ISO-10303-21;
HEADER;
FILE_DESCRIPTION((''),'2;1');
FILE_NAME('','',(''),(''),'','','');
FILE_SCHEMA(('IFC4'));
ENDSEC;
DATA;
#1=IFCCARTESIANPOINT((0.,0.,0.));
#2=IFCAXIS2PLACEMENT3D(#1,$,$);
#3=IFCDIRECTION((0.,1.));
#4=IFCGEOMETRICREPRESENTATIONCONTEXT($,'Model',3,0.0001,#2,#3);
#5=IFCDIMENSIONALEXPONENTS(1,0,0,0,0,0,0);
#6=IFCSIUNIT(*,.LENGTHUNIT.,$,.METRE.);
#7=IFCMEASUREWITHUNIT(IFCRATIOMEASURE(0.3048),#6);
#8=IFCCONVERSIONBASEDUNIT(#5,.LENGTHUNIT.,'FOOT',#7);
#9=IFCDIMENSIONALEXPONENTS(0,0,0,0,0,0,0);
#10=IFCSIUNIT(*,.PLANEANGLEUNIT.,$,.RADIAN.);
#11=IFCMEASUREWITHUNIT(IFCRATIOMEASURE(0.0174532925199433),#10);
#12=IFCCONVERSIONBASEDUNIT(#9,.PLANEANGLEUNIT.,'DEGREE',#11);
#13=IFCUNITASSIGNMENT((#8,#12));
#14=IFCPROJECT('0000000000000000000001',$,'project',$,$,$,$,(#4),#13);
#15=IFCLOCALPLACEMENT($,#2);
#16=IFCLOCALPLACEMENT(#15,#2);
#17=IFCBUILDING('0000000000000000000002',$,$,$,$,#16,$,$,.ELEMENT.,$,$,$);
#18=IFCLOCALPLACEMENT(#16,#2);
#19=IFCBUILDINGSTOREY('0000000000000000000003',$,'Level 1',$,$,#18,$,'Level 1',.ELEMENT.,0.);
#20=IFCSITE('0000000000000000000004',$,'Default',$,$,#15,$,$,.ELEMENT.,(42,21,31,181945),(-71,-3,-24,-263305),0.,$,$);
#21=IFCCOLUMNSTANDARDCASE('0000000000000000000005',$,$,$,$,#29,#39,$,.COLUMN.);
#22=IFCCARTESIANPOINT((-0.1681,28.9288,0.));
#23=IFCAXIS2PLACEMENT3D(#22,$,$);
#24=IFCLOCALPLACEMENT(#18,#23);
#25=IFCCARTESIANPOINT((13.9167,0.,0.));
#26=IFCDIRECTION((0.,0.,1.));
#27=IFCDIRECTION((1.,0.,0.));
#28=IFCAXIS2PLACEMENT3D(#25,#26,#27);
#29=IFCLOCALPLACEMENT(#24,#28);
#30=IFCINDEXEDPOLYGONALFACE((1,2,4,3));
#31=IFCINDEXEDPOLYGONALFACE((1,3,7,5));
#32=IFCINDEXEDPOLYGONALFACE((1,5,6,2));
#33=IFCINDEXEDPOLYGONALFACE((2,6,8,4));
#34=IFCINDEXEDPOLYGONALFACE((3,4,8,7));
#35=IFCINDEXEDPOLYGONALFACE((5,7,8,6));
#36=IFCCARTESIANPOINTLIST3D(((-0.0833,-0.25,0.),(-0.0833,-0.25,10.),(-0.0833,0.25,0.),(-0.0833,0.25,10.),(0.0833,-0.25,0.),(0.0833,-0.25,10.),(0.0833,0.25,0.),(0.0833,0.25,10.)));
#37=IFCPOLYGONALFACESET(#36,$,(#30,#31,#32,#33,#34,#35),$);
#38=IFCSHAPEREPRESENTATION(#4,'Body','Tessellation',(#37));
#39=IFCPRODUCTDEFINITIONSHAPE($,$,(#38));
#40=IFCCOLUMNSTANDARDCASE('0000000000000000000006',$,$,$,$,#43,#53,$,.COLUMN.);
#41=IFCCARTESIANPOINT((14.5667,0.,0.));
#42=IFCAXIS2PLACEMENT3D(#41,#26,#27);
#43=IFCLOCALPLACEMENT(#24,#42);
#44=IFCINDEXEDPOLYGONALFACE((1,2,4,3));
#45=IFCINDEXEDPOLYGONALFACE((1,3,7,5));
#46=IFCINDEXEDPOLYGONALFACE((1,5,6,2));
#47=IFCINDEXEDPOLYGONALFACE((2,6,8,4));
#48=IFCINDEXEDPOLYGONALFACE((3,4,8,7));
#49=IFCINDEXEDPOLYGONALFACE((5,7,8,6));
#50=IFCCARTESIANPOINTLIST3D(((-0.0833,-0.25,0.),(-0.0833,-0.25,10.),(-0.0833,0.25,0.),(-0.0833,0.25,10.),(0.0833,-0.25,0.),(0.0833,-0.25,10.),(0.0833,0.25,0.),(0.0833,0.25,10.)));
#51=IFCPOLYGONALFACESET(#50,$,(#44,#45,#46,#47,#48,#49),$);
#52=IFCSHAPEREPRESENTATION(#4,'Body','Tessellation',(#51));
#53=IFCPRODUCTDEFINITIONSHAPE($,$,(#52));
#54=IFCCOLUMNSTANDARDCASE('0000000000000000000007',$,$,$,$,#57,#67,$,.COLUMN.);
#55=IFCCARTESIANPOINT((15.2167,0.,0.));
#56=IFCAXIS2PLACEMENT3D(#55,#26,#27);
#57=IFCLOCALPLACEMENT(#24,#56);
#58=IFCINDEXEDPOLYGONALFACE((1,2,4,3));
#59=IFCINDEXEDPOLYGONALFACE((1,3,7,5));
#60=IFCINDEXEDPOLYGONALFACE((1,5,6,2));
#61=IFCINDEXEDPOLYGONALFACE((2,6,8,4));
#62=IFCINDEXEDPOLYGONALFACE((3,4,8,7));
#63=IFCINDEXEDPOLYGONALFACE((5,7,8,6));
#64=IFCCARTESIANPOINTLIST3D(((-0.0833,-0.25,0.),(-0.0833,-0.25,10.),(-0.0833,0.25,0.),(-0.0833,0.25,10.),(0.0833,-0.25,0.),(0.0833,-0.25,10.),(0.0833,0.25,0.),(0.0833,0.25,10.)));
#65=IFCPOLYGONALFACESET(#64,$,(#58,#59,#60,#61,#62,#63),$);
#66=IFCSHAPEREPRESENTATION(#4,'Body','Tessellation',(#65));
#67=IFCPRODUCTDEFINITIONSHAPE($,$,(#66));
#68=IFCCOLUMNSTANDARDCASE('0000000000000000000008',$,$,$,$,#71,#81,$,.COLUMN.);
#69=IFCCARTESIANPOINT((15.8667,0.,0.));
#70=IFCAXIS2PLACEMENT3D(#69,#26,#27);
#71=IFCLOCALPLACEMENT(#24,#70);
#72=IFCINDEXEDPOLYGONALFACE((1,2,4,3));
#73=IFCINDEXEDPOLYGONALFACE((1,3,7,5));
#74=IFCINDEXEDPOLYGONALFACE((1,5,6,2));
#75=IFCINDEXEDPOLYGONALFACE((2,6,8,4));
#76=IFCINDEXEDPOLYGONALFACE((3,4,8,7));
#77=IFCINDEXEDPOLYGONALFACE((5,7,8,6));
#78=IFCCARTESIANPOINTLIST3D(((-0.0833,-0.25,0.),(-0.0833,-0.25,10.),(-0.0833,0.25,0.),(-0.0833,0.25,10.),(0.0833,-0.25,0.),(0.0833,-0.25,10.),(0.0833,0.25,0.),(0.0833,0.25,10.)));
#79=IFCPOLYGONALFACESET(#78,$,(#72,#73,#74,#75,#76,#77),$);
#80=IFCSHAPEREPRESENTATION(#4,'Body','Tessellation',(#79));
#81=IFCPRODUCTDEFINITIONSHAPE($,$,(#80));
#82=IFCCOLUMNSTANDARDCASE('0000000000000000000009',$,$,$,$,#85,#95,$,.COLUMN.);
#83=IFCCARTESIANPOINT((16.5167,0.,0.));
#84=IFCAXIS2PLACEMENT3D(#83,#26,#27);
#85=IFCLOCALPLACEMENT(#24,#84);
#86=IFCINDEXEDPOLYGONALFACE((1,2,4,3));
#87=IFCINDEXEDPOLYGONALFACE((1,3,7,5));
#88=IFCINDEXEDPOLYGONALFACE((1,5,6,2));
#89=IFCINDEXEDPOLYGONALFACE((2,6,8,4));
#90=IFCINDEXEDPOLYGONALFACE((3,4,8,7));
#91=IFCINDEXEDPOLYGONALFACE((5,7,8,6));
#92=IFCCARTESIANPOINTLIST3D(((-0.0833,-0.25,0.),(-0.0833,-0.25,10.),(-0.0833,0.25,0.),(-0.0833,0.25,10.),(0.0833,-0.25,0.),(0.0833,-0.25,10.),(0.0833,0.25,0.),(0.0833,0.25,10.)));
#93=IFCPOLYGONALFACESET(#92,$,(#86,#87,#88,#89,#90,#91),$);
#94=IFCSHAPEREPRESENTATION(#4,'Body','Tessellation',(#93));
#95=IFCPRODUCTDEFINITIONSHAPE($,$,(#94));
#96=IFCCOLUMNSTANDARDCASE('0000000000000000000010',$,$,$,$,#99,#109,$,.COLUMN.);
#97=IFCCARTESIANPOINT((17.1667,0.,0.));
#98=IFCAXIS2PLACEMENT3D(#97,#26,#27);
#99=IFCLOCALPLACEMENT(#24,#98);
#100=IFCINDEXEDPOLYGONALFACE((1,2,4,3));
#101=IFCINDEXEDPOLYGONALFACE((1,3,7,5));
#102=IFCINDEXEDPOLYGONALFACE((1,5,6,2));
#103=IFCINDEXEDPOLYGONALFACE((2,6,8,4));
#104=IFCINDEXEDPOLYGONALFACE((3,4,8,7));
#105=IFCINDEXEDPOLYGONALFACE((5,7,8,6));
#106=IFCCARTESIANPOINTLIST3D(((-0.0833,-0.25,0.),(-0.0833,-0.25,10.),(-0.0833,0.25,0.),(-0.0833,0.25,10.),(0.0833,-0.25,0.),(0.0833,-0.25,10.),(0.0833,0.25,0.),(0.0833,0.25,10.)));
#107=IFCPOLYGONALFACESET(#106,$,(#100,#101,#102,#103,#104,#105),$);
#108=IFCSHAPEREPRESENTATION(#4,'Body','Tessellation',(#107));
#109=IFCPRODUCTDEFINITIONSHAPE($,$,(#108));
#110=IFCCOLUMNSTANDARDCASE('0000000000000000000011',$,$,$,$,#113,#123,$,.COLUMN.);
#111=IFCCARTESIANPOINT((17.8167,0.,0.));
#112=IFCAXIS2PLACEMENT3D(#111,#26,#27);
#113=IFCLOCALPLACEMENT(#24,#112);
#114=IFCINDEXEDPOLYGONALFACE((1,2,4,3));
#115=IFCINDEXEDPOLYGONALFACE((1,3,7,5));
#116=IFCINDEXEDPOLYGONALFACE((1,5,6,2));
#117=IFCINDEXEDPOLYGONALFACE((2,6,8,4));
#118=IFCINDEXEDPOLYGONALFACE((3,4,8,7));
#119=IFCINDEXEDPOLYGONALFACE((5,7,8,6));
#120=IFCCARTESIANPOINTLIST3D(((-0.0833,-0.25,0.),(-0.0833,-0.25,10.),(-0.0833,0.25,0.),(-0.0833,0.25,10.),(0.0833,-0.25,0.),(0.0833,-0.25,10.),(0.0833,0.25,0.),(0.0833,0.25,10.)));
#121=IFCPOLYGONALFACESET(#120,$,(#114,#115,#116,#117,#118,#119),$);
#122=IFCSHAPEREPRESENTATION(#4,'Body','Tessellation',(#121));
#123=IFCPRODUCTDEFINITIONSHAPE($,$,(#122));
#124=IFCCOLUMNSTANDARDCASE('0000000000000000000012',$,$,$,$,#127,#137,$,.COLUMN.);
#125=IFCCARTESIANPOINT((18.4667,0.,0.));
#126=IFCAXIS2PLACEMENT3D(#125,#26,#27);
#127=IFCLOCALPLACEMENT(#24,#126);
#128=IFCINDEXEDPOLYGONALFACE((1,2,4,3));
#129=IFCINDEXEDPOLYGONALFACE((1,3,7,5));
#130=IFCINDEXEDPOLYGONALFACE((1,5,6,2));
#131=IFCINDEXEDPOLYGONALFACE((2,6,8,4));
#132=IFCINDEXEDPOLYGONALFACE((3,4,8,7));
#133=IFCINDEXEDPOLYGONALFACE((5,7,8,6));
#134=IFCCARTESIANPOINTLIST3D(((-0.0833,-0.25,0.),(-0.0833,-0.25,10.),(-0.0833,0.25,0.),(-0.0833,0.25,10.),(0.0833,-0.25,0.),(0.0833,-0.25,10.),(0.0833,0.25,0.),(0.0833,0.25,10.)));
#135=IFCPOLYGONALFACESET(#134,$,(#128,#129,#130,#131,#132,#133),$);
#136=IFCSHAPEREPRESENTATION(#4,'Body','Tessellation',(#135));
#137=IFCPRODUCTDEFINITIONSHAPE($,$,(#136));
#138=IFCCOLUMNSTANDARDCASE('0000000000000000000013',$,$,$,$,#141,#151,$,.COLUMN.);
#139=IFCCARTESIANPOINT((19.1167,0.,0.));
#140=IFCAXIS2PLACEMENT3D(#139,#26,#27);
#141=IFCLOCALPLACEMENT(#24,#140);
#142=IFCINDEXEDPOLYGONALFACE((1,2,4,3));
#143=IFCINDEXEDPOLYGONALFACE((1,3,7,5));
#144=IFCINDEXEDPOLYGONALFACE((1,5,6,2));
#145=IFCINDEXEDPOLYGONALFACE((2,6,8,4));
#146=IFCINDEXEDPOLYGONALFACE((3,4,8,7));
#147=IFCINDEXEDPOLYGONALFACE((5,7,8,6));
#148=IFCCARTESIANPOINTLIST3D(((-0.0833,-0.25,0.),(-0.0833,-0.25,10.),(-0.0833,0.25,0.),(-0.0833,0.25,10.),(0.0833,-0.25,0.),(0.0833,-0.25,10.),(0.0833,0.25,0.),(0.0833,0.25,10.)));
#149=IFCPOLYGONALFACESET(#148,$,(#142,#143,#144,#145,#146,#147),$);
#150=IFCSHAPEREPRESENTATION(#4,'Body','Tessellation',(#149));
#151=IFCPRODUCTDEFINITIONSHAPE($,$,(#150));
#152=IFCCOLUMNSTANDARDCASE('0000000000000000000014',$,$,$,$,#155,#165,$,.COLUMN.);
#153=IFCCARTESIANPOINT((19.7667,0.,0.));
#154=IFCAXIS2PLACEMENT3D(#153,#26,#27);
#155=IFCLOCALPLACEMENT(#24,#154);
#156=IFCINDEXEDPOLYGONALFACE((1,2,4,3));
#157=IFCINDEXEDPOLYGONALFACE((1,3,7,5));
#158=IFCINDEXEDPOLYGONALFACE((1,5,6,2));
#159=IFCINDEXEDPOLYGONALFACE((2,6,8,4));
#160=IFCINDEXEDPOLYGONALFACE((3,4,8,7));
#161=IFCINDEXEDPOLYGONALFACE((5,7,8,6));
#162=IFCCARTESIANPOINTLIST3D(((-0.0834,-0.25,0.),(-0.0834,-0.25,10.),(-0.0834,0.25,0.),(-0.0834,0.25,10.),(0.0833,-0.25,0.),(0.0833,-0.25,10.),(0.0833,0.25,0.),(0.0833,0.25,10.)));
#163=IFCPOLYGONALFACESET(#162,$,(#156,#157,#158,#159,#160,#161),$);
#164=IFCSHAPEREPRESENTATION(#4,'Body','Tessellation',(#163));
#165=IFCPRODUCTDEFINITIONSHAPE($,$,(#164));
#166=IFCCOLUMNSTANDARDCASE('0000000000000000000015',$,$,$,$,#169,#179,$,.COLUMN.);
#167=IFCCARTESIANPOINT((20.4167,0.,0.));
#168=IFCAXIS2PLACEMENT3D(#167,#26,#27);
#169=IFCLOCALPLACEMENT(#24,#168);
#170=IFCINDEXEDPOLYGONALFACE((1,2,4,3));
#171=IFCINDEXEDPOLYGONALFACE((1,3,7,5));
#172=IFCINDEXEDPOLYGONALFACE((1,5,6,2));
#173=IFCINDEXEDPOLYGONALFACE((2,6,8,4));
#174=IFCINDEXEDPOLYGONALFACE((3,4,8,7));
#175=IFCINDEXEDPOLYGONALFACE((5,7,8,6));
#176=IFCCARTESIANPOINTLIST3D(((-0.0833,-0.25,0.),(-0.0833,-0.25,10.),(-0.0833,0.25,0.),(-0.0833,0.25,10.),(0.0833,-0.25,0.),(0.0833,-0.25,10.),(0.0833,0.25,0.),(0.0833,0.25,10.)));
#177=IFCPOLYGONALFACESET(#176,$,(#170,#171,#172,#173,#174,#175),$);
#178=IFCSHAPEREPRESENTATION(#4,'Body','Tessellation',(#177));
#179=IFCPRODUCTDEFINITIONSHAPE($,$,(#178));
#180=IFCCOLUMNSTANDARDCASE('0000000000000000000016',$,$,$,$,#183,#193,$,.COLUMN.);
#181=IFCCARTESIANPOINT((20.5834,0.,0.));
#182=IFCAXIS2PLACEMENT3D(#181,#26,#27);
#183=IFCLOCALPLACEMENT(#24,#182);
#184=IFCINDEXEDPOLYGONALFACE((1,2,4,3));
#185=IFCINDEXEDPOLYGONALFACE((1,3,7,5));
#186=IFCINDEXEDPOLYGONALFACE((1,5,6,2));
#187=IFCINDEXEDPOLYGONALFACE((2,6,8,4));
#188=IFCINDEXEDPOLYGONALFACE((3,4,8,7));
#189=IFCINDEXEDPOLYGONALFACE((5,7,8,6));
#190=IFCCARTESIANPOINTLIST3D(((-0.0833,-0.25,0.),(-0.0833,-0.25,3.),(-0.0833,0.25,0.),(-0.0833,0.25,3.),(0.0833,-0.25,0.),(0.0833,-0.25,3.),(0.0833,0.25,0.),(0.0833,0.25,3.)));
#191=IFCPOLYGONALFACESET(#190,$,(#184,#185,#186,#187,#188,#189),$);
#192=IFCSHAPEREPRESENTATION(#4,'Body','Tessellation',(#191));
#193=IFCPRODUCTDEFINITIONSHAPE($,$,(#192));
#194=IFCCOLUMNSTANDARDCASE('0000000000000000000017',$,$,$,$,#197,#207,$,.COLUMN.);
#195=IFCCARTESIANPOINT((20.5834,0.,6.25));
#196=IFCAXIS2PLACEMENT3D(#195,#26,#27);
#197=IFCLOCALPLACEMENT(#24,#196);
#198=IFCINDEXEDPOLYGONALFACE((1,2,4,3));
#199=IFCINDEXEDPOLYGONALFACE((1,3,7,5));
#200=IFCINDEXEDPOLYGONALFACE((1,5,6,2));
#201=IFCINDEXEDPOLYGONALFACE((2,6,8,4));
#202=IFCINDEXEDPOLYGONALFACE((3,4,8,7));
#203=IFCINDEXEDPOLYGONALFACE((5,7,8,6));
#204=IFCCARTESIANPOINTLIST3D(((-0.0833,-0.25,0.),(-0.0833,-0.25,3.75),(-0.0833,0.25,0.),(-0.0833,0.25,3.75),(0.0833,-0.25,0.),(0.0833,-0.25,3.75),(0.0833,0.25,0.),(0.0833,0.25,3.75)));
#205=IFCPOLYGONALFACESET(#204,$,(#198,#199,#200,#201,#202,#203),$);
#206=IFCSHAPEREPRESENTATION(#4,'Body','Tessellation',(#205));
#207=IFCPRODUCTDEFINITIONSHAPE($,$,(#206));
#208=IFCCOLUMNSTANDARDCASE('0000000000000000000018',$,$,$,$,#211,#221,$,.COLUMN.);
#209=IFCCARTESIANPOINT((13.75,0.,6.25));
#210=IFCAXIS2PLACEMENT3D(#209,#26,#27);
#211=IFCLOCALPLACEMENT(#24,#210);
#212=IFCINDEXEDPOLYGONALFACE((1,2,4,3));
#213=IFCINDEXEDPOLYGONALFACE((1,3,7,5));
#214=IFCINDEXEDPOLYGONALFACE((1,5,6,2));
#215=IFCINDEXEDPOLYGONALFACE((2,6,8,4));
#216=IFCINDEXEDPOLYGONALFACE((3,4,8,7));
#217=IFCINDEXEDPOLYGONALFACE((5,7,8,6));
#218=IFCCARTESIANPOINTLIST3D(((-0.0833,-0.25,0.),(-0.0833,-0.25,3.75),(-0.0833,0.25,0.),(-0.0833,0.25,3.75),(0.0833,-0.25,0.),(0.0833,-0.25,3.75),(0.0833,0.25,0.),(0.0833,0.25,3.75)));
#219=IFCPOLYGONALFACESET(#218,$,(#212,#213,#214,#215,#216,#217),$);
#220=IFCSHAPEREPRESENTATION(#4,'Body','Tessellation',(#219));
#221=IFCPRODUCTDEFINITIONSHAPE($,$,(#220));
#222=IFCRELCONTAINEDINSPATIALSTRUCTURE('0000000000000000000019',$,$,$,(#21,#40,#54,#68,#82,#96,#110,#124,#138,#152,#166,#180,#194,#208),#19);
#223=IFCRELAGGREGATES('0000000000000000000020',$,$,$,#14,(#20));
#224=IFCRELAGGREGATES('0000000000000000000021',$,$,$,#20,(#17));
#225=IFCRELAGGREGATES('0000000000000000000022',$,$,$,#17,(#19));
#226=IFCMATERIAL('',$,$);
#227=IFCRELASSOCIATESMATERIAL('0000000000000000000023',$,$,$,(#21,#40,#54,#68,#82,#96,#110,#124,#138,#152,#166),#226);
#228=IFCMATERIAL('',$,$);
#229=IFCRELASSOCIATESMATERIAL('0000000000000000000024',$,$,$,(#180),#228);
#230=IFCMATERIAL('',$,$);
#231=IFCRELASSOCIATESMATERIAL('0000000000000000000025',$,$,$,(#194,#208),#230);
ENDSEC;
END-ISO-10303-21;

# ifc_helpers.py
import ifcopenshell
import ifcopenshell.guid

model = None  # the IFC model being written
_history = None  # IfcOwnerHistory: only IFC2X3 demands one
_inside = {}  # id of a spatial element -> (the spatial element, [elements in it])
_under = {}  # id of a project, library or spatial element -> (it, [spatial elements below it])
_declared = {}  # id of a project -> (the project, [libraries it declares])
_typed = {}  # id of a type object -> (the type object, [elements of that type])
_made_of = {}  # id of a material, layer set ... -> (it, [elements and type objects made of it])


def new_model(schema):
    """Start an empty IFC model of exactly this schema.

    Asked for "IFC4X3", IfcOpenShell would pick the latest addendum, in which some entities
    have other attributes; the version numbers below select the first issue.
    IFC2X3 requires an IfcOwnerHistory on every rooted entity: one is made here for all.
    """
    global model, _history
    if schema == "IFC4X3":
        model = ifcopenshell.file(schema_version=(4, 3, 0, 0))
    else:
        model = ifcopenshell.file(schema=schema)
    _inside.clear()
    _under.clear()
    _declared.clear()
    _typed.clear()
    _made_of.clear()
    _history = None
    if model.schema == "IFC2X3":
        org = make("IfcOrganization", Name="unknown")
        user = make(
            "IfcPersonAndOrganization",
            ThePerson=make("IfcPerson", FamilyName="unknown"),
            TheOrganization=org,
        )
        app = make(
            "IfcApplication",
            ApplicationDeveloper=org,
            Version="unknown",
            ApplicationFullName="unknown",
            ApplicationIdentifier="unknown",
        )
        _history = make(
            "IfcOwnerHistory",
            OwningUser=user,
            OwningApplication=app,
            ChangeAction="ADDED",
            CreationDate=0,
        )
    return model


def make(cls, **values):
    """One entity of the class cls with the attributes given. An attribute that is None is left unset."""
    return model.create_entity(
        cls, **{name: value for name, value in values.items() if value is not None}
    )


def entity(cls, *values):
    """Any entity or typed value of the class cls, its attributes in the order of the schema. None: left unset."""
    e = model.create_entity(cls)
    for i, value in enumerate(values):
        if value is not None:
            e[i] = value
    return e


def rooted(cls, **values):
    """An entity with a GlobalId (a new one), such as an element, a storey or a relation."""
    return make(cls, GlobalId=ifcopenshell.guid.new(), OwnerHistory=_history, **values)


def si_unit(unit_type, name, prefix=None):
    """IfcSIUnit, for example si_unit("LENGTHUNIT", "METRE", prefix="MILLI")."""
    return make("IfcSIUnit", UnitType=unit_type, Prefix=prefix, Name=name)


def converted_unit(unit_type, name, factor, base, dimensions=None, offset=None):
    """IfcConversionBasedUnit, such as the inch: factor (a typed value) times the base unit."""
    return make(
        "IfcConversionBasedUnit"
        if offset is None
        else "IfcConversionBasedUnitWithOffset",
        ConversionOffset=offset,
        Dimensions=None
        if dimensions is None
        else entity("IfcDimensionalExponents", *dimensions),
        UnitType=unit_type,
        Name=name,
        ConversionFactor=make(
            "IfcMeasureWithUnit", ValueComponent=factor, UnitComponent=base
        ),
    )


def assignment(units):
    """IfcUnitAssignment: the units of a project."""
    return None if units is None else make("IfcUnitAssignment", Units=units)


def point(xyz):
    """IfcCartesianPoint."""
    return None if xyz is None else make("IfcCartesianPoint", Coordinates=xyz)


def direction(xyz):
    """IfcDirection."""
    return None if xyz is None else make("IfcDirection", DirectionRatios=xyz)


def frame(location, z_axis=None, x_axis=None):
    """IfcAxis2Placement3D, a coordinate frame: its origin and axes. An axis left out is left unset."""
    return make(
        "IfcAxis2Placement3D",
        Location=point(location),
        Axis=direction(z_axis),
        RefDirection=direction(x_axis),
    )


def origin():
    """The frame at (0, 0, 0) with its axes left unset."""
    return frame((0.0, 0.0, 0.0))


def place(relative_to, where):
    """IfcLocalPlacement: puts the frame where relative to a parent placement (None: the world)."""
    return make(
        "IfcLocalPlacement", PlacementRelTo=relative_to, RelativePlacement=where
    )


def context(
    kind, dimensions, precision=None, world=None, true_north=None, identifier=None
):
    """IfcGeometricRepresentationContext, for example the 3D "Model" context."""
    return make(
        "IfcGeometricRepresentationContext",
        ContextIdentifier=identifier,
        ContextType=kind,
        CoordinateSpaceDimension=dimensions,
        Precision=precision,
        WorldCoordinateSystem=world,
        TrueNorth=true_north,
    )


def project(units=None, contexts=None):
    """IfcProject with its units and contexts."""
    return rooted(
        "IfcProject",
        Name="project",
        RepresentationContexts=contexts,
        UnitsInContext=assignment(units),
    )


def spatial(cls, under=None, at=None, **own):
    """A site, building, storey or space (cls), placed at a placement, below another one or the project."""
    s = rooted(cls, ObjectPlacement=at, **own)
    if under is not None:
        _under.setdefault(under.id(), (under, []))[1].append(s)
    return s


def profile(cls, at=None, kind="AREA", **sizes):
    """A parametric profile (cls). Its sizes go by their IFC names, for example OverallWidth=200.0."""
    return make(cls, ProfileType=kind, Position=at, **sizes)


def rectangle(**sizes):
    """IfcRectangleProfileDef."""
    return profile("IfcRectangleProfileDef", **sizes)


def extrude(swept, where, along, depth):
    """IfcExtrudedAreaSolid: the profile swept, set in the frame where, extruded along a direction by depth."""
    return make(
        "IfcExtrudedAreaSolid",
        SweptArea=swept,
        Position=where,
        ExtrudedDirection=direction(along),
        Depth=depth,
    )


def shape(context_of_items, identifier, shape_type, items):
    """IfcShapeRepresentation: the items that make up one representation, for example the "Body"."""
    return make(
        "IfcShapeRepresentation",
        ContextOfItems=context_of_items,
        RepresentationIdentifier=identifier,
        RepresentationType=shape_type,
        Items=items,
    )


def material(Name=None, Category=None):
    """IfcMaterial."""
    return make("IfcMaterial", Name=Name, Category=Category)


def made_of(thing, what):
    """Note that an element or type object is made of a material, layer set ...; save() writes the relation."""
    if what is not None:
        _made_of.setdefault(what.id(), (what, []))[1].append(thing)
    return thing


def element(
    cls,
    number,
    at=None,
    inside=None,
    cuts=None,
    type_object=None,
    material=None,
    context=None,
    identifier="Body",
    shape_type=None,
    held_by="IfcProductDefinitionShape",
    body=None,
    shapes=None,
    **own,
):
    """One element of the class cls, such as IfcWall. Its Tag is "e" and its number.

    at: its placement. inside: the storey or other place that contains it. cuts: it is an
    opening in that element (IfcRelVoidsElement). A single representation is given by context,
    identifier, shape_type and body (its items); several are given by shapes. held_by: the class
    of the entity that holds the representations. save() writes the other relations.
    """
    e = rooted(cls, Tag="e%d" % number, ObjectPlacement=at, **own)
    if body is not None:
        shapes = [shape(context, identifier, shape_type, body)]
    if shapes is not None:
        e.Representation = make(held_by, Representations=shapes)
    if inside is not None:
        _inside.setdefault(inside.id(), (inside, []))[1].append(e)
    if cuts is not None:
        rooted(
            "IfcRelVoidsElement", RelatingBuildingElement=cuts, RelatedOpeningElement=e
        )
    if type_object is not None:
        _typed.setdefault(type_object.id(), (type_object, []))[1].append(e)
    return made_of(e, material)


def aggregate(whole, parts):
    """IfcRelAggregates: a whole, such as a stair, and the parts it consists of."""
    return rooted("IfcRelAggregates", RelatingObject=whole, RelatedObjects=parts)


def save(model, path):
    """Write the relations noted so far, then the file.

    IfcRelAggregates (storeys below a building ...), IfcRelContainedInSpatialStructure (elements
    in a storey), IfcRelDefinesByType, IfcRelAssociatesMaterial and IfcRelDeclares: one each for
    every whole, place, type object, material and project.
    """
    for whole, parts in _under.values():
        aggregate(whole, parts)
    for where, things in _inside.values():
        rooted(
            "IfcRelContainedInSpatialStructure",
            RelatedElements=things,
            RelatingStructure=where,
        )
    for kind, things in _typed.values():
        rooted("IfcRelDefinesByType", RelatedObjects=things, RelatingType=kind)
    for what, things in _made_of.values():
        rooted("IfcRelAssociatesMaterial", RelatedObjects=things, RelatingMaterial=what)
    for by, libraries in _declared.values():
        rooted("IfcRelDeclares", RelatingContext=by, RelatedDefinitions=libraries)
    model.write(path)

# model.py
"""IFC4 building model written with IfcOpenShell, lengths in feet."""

from ifc_helpers import new_model, entity, si_unit, converted_unit, direction, frame, origin, place, context, project, spatial, rectangle, extrude, material, element, save


model = new_model("IFC4")

# Units and contexts
model_context = context("Model", 3, precision=0.0001, world=origin(), true_north=direction((0.0, 1.0)))
ifc_project = project(units=[converted_unit("LENGTHUNIT", "FOOT", entity("IfcRatioMeasure", 0.3048), si_unit("LENGTHUNIT", "METRE"), dimensions=[1, 0, 0, 0, 0, 0, 0]), converted_unit("PLANEANGLEUNIT", "DEGREE", entity("IfcRatioMeasure", 0.0174532925199433), si_unit("PLANEANGLEUNIT", "RADIAN"), dimensions=[0, 0, 0, 0, 0, 0, 0])], contexts=[model_context])

# Site, building, storey
site_placement = place(None, origin())
site = spatial("IfcSite", under=ifc_project, at=site_placement, Name="Default", CompositionType="ELEMENT", RefLatitude=(42, 21, 31, 181945), RefLongitude=(-71, -3, -24, -263305), RefElevation=0.0)
building_placement = place(site_placement, origin())
building = spatial("IfcBuilding", under=site, at=building_placement, CompositionType="ELEMENT")
storey_placement = place(building_placement, origin())
storey = spatial("IfcBuildingStorey", under=building, at=storey_placement, Name="Level 1", LongName="Level 1", CompositionType="ELEMENT", Elevation=0.0)

# Columns
ifc_material_1 = material(Name="")
placement = place(storey_placement, frame((-0.1681, 28.9288, 0.0)))
for number, where, z_axis, x_axis in (
    (1, (13.9167, 0.0, 0.0), (0.0, 0.0, 1.0), (1.0, 0.0, 0.0)),
    (2, (14.5667, 0.0, 0.0), (0.0, 0.0, 1.0), (1.0, 0.0, 0.0)),
    (3, (15.2167, 0.0, 0.0), (0.0, 0.0, 1.0), (1.0, 0.0, 0.0)),
    (4, (15.8667, 0.0, 0.0), (0.0, 0.0, 1.0), (1.0, 0.0, 0.0)),
    (5, (16.5167, 0.0, 0.0), (0.0, 0.0, 1.0), (1.0, 0.0, 0.0)),
    (6, (17.1667, 0.0, 0.0), (0.0, 0.0, 1.0), (1.0, 0.0, 0.0)),
    (7, (17.8167, 0.0, 0.0), (0.0, 0.0, 1.0), (1.0, 0.0, 0.0)),
    (8, (18.4667, 0.0, 0.0), (0.0, 0.0, 1.0), (1.0, 0.0, 0.0)),
    (9, (19.1167, 0.0, 0.0), (0.0, 0.0, 1.0), (1.0, 0.0, 0.0)),
    (10, (19.7667, 0.0, 0.0), (0.0, 0.0, 1.0), (1.0, 0.0, 0.0)),
    (11, (20.4167, 0.0, 0.0), (0.0, 0.0, 1.0), (1.0, 0.0, 0.0)),
):
    element("IfcColumnStandardCase", number, at=place(placement, frame(where, z_axis=z_axis, x_axis=x_axis)), inside=storey, material=ifc_material_1, PredefinedType="COLUMN", context=model_context, shape_type="SweptSolid", body=[
        extrude(rectangle(XDim=0.1667, YDim=0.5), origin(), (0.0, 0.0, 1.0), 10.0),
    ])
ifc_material_2 = material(Name="")
for number, where, z_axis, x_axis in (
    (12, (20.5834, 0.0, 0.0), (0.0, 0.0, 1.0), (1.0, 0.0, 0.0)),
):
    element("IfcColumnStandardCase", number, at=place(placement, frame(where, z_axis=z_axis, x_axis=x_axis)), inside=storey, material=ifc_material_2, PredefinedType="COLUMN", context=model_context, shape_type="SweptSolid", body=[
        extrude(rectangle(XDim=0.1667, YDim=0.5), origin(), (0.0, 0.0, 1.0), 3.0),
    ])
ifc_material_3 = material(Name="")
for number, where, z_axis, x_axis in (
    (13, (20.5834, 0.0, 6.25), (0.0, 0.0, 1.0), (1.0, 0.0, 0.0)),
    (14, (13.75, 0.0, 6.25), (0.0, 0.0, 1.0), (1.0, 0.0, 0.0)),
):
    element("IfcColumnStandardCase", number, at=place(placement, frame(where, z_axis=z_axis, x_axis=x_axis)), inside=storey, material=ifc_material_3, PredefinedType="COLUMN", context=model_context, shape_type="SweptSolid", body=[
        extrude(rectangle(XDim=0.1667, YDim=0.5), origin(), (0.0, 0.0, 1.0), 3.75),
    ])

save(model, "model.ifc")
